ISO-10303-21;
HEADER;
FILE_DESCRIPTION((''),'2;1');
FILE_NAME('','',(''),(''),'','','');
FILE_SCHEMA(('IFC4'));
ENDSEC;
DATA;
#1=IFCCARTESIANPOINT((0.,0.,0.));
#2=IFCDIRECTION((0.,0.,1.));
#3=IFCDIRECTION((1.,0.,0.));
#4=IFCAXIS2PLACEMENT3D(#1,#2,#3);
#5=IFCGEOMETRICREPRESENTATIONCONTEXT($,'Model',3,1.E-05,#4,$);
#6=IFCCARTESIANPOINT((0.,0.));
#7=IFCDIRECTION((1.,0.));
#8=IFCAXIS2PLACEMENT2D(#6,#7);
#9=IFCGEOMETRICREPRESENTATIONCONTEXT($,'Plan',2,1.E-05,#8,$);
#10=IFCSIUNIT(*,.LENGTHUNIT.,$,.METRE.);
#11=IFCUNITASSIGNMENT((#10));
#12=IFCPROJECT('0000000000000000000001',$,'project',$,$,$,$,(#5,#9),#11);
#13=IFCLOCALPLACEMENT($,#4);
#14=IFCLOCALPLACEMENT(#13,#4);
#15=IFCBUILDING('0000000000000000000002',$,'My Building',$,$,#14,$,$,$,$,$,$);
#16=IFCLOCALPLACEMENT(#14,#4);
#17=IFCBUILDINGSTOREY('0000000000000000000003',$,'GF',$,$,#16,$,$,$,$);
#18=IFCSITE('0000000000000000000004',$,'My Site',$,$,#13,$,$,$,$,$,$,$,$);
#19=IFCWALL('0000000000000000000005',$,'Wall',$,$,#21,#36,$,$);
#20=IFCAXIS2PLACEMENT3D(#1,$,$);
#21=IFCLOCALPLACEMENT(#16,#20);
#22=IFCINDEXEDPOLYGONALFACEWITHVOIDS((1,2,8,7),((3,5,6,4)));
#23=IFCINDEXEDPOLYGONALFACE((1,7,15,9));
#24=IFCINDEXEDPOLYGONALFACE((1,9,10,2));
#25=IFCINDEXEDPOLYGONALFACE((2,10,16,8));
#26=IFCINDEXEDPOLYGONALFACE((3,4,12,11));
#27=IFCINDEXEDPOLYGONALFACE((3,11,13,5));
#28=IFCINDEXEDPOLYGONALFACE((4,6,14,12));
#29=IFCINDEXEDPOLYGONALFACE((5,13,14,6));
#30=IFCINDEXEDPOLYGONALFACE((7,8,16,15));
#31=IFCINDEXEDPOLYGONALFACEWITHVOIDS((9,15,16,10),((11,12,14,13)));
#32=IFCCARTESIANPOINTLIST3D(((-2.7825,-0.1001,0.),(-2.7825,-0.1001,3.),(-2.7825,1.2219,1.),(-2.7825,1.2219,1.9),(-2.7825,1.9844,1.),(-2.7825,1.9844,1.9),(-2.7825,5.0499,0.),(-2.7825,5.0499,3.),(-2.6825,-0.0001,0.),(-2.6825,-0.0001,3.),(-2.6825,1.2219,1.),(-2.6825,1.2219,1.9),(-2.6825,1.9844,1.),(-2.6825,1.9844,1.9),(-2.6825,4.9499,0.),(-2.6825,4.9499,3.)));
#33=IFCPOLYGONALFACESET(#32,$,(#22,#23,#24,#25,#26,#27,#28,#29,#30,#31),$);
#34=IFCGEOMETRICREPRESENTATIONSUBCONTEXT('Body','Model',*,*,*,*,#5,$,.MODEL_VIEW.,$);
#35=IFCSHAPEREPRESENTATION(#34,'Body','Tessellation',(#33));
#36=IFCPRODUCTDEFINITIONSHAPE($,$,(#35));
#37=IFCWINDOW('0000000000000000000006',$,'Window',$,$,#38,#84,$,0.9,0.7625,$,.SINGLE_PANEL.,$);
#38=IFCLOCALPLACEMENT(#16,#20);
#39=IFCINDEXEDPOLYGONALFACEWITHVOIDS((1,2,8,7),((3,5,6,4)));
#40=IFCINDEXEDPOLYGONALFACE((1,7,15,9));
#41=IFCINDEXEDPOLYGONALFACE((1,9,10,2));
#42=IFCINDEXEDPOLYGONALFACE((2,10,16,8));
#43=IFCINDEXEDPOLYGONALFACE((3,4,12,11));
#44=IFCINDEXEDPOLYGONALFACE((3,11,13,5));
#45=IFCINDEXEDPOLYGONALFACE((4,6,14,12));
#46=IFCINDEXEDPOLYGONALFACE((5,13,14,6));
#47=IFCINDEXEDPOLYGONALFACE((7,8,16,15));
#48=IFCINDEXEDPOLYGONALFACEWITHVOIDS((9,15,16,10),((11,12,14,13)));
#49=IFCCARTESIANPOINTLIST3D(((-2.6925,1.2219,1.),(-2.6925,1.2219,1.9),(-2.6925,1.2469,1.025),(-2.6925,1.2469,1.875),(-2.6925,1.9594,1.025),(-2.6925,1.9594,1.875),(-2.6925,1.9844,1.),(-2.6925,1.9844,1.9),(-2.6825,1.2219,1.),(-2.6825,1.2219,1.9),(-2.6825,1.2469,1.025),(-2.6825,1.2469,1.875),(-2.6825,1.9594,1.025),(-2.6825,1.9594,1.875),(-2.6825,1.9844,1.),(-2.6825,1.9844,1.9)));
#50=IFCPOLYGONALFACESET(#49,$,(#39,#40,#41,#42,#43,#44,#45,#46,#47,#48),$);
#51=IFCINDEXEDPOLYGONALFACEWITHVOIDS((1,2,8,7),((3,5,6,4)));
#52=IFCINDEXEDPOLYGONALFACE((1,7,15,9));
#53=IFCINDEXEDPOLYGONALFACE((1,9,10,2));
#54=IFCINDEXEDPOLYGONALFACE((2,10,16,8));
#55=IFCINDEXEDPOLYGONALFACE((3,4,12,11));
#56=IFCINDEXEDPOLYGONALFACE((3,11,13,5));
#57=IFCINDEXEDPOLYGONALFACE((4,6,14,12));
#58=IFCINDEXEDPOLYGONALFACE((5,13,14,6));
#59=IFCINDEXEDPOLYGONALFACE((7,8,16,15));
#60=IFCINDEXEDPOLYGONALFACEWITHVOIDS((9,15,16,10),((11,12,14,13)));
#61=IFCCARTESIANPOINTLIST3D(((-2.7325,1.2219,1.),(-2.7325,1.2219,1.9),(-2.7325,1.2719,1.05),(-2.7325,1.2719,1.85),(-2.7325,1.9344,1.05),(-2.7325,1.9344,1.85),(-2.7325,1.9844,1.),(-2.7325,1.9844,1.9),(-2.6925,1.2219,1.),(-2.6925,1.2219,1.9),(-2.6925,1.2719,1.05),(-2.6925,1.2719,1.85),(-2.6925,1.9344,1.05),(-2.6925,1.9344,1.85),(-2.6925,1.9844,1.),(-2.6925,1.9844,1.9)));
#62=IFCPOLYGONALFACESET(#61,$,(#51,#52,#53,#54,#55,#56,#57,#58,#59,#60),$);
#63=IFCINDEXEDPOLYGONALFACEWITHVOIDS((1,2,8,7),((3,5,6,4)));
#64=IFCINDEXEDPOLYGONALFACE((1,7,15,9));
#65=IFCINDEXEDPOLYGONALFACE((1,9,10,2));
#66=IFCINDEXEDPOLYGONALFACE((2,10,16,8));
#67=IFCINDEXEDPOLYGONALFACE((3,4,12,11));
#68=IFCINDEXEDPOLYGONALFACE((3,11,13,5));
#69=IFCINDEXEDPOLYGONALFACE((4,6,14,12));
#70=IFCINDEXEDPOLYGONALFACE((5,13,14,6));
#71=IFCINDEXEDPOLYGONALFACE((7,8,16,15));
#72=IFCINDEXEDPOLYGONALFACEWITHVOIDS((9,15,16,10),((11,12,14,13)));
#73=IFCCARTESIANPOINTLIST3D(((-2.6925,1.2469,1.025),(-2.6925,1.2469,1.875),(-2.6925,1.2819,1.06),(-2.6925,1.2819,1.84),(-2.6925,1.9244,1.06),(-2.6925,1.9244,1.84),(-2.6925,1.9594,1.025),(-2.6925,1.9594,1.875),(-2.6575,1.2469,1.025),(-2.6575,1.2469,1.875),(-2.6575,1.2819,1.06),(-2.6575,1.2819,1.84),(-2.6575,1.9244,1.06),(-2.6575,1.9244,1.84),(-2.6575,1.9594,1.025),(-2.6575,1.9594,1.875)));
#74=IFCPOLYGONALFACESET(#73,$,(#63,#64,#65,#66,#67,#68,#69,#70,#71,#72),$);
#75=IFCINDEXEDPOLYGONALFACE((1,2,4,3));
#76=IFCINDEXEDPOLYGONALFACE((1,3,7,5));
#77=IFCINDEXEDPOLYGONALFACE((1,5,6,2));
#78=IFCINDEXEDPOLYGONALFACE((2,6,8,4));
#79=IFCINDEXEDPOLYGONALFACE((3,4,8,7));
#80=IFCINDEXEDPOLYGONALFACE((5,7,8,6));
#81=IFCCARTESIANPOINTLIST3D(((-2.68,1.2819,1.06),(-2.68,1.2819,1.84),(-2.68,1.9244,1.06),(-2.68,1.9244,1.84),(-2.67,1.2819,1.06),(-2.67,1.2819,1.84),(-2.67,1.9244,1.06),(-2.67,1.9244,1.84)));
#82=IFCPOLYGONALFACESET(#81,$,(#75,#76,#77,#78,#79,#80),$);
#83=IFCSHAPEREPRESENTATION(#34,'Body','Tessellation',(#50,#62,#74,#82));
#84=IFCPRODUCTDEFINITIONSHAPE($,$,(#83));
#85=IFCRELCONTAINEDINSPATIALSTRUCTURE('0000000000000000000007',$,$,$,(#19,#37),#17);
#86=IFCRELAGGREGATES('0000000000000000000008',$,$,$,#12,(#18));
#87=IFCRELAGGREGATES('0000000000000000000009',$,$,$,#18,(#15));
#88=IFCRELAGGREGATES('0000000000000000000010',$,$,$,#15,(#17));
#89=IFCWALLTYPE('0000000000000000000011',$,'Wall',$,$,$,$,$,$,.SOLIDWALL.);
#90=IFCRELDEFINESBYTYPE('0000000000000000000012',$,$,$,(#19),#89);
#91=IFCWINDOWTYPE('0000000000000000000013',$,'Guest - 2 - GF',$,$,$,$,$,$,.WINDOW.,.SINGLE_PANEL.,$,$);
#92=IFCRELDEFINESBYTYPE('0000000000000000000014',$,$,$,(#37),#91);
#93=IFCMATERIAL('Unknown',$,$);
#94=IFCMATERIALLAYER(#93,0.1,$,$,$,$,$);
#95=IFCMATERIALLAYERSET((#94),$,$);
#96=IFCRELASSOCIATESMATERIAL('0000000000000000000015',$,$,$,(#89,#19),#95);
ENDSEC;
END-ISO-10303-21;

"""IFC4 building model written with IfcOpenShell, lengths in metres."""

from ifc_helpers import new_model, entity, si_unit, frame, origin_with_axes, origin_2d_with_axis, place, context, subcontext, project, spatial, line, indexed_curve, outline, extrude, shape, source, transform, mapped, material, layer, layer_set, layer_usage, type_object, type_shapes, element, fill, save


model = new_model("IFC4")

# Units and contexts
model_context = context("Model", 3, precision=1e-05, world=origin_with_axes())
plan_context = context("Plan", 2, precision=1e-05, world=origin_2d_with_axis())
body_context_1 = subcontext(model_context, "Body", "Model", "MODEL_VIEW")
body_context_2 = subcontext(plan_context, "Body", "Plan", "PLAN_VIEW")
ifc_project = project(units=[si_unit("LENGTHUNIT", "METRE")], contexts=[model_context, plan_context])

# Site, building, storey
site_placement = place(None, origin_with_axes())
site = spatial("IfcSite", under=ifc_project, at=site_placement, Name="My Site")
building_placement = place(site_placement, origin_with_axes())
building = spatial("IfcBuilding", under=site, at=building_placement, Name="My Building")
storey_placement = place(building_placement, origin_with_axes())
storey = spatial("IfcBuildingStorey", under=building, at=storey_placement, Name="GF")

# Shared definitions
ifc_material = material(Name="Unknown")

# Shared definitions
ifc_layer_1 = layer(ifc_material, 0.1)
ifc_layer_set_1 = layer_set([ifc_layer_1])
wall_type = type_object("IfcWallType", Name="Wall", PredefinedType="SOLIDWALL", material=ifc_layer_set_1)

# Wall, opening, window
ifc_layer_usage_1 = layer_usage(ifc_layer_set_1, "AXIS2", "POSITIVE", 0.0)
wall_1_placement = place(storey_placement, frame((-2.7825, 5.0499, 0.0), z_axis=(0.0, 0.0, 1.0), x_axis=(0.0, -1.0, 0.0)))
wall_1 = element("IfcWall", 1, at=wall_1_placement, inside=storey, type_object=wall_type, material=ifc_layer_usage_1, Name="Wall", context=body_context_1, shape_type="SweptSolid", body=[
    extrude(outline(indexed_curve([(0.0, 0.0), (0.1, 0.1), (5.05, 0.1), (5.15, 0.0)], segments=[line(1, 2, 3, 4, 1)])), origin_with_axes(), (0.0, 0.0, 1.0), 3.0),
])
shared_shape_1 = source(origin_with_axes(), body_context_1, "Body", "SweptSolid", [
    extrude(outline(indexed_curve([(0.0, 0.0), (0.7625, 0.0), (0.7625, 0.9), (0.0, 0.9)], segments=[line(1, 2, 3, 4, 1)])), frame((0.0, -0.6, 0.0), z_axis=(0.0, -1.0, 0.0), x_axis=(1.0, 0.0, 0.0)), (0.0, 0.0, -1.0), 1.2),
])
opening_1_placement = place(wall_1_placement, frame((3.0656, 0.0, 1.0), z_axis=(0.0, 0.0, 1.0), x_axis=(1.0, 0.0, 0.0)))
opening_1 = element("IfcOpeningElement", 2, at=opening_1_placement, cuts=wall_1, PredefinedType="OPENING", context=body_context_1, shape_type="MappedRepresentation", body=[
    mapped(shared_shape_1, transform((0.0, 0.0, 0.0), x_axis=(1.0, 0.0, 0.0), y_axis=(0.0, 1.0, 0.0), z_axis=(0.0, 0.0, 1.0), scale=1.0)),
])
window_type_1 = type_object("IfcWindowType", Name="Guest - 2 - GF", PartitioningType="SINGLE_PANEL", PredefinedType="WINDOW")
shared_shape_2 = source(origin_with_axes(), body_context_1, "Body", "SweptSolid", [
    extrude(outline(indexed_curve([(0.0, 0.0), (0.7625, 0.0), (0.7625, 0.9), (0.0, 0.9)], segments=[line(1, 2, 3, 4, 1)]), holes=[indexed_curve([(0.025, 0.025), (0.7375, 0.025), (0.7375, 0.875), (0.025, 0.875)], segments=[line(1, 2, 3, 4, 1)])]), frame((0.0, 0.09, 0.0), z_axis=(0.0, -1.0, 0.0), x_axis=(1.0, 0.0, 0.0)), (0.0, 0.0, -1.0), 0.01),
    extrude(outline(indexed_curve([(0.0, 0.0), (0.7625, 0.0), (0.7625, 0.9), (0.0, 0.9)], segments=[line(1, 2, 3, 4, 1)]), holes=[indexed_curve([(0.05, 0.05), (0.7125, 0.05), (0.7125, 0.85), (0.05, 0.85)], segments=[line(1, 2, 3, 4, 1)])]), frame((0.0, 0.05, 0.0), z_axis=(0.0, -1.0, 0.0), x_axis=(1.0, 0.0, 0.0)), (0.0, 0.0, -1.0), 0.04),
    extrude(outline(indexed_curve([(0.0, 0.0), (0.7125, 0.0), (0.7125, 0.85), (0.0, 0.85)], segments=[line(1, 2, 3, 4, 1)]), holes=[indexed_curve([(0.035, 0.035), (0.6775, 0.035), (0.6775, 0.815), (0.035, 0.815)], segments=[line(1, 2, 3, 4, 1)])]), frame((0.025, 0.09, 0.025), z_axis=(0.0, -1.0, 0.0), x_axis=(1.0, 0.0, 0.0)), (0.0, 0.0, -1.0), 0.035),
    extrude(outline(indexed_curve([(0.035, 0.035), (0.6775, 0.035), (0.6775, 0.815), (0.035, 0.815)], segments=[line(1, 2, 3, 4, 1)])), frame((0.025, 0.1025, 0.025), z_axis=(0.0, -1.0, 0.0), x_axis=(1.0, 0.0, 0.0)), (0.0, 0.0, -1.0), 0.01),
])
shared_shape_3 = source(origin_with_axes(), body_context_2, "Body", "Curve2D", [
    entity("IfcIndexedPolyCurve", entity("IfcCartesianPointList2D", [[0.05, 0.05], [0.7125, 0.05]])),
    entity("IfcIndexedPolyCurve", entity("IfcCartesianPointList2D", [[0.0, 0.1], [0.025, 0.1], [0.025, 0.09], [0.05, 0.09], [0.05, 0.05], [0.0, 0.05]]), [entity("IfcLineIndex", [1, 2, 3, 4, 5, 6, 1])]),
    entity("IfcIndexedPolyCurve", entity("IfcCartesianPointList2D", [[0.7625, 0.1], [0.7375, 0.1], [0.7375, 0.09], [0.7125, 0.09], [0.7125, 0.05], [0.7625, 0.05]]), [entity("IfcLineIndex", [1, 2, 3, 4, 5, 6, 1])]),
    entity("IfcIndexedPolyCurve", entity("IfcCartesianPointList2D", [[0.025, 0.09], [0.06, 0.09], [0.06, 0.125], [0.025, 0.125]]), [entity("IfcLineIndex", [1, 2, 3, 4, 1])]),
    entity("IfcIndexedPolyCurve", entity("IfcCartesianPointList2D", [[0.7375, 0.09], [0.7025, 0.09], [0.7025, 0.125], [0.7375, 0.125]]), [entity("IfcLineIndex", [1, 2, 3, 4, 1])]),
    entity("IfcIndexedPolyCurve", entity("IfcCartesianPointList2D", [[0.06, 0.09], [0.7025, 0.09]])),
    entity("IfcIndexedPolyCurve", entity("IfcCartesianPointList2D", [[0.06, 0.125], [0.7025, 0.125]])),
    entity("IfcIndexedPolyCurve", entity("IfcCartesianPointList2D", [[0.06, 0.1075], [0.7025, 0.1075]])),
])
type_shapes(window_type_1, [shared_shape_2, shared_shape_3])
window_1_placement = place(opening_1_placement, frame((0.0, 0.0, 0.0), z_axis=(0.0, 0.0, 1.0), x_axis=(1.0, 0.0, 0.0)))
window_1 = element("IfcWindow", 3, at=window_1_placement, inside=storey, type_object=window_type_1, Name="Window", OverallHeight=0.9, OverallWidth=0.7625, PartitioningType="SINGLE_PANEL", shapes=[
    shape(body_context_1, "Body", "MappedRepresentation", [mapped(shared_shape_2, transform((0.0, 0.0, 0.0), x_axis=(1.0, 0.0, 0.0), y_axis=(0.0, 1.0, 0.0), z_axis=(0.0, 0.0, 1.0), scale=1.0))]),
    shape(body_context_2, "Body", "MappedRepresentation", [mapped(shared_shape_3, transform((0.0, 0.0, 0.0), x_axis=(1.0, 0.0, 0.0), y_axis=(0.0, 1.0, 0.0), z_axis=(0.0, 0.0, 1.0), scale=1.0))]),
])
fill(opening_1, window_1)

save(model, "model.ifc")
